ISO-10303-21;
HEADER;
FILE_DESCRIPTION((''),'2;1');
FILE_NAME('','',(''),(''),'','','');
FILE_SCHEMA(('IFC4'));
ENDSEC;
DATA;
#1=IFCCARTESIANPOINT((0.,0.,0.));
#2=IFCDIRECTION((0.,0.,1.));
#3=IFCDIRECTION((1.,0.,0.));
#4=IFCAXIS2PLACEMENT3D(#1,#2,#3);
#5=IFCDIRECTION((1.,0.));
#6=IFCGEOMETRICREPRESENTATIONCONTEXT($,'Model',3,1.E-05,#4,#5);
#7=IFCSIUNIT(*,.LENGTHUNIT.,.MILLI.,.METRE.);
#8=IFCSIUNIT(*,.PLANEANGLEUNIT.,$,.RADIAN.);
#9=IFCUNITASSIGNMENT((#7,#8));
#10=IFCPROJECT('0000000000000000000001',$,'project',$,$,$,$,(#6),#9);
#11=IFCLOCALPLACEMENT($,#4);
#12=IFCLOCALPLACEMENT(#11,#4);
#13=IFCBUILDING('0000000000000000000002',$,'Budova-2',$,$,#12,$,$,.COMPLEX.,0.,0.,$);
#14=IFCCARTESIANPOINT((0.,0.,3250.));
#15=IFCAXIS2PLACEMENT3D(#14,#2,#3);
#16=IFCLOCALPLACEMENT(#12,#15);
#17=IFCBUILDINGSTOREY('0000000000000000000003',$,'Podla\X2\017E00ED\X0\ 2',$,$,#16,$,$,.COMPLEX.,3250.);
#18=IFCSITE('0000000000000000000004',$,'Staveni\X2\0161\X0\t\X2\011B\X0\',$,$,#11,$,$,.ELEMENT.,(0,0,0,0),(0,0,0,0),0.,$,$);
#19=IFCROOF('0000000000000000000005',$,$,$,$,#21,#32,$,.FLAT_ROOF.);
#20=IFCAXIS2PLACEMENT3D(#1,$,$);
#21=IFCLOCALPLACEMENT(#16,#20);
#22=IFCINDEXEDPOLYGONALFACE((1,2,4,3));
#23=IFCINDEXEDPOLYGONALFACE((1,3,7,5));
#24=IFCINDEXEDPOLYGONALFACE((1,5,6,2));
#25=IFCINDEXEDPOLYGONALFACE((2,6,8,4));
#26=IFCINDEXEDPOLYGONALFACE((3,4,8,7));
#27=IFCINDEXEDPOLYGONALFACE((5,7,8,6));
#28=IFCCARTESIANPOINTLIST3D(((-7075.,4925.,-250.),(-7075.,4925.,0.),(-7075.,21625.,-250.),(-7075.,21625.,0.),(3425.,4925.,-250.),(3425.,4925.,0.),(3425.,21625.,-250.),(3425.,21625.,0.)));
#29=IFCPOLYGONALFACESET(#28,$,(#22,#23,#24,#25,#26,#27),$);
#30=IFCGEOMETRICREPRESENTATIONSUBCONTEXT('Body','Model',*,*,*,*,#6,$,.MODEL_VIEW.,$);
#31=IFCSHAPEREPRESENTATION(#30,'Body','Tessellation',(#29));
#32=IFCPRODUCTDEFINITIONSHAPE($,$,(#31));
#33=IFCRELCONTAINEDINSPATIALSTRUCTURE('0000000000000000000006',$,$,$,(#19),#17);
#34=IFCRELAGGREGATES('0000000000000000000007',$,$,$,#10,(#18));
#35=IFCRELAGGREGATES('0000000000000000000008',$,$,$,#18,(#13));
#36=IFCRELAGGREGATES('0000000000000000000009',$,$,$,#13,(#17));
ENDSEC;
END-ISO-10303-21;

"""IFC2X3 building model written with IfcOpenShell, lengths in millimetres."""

from ifc_helpers import new_model, si_unit, direction, frame, frame_2d, origin_with_axes, place, context, subcontext, project, spatial, rectangle, extrude, element, save


model = new_model("IFC2X3")

# Units and contexts
model_context = context("Model", 3, precision=1e-05, world=origin_with_axes(), true_north=direction((1.0, 0.0)))
body_context = subcontext(model_context, "Body", "Model", "MODEL_VIEW")
ifc_project = project(units=[si_unit("LENGTHUNIT", "METRE", prefix="MILLI"), si_unit("PLANEANGLEUNIT", "RADIAN")], contexts=[model_context])

# Site, building, storey
site_placement = place(None, origin_with_axes())
site = spatial("IfcSite", under=ifc_project, at=site_placement, Name="Staveniště", CompositionType="ELEMENT", RefLatitude=(0, 0, 0, 0), RefLongitude=(0, 0, 0, 0), RefElevation=0.0)
building_placement = place(site_placement, origin_with_axes())
building = spatial("IfcBuilding", under=site, at=building_placement, Name="Budova-2", CompositionType="COMPLEX", ElevationOfRefHeight=0.0, ElevationOfTerrain=0.0)
storey_placement = place(building_placement, frame((0.0, 0.0, 3250.0), z_axis=(0.0, 0.0, 1.0), x_axis=(1.0, 0.0, 0.0)))
storey = spatial("IfcBuildingStorey", under=building, at=storey_placement, Name="Podlaží 2", CompositionType="COMPLEX", Elevation=3250.0)

# Roof
roof_placement = place(storey_placement, frame((-7075.0, 21625.0, -250.0), z_axis=(0.0, 0.0, 1.0), x_axis=(0.0, -1.0, 0.0)))
element("IfcRoof", 1, at=roof_placement, inside=storey, ShapeType="FLAT_ROOF", context=body_context, shape_type="SweptSolid", body=[
    extrude(rectangle(XDim=16700.0, YDim=10500.0, at=frame_2d((0.0, 0.0), x_axis=(-1.0, 0.0))), frame((8350.0, 5250.0, 0.0), z_axis=(0.0, 0.0, 1.0), x_axis=(1.0, 0.0, 0.0)), (0.0, 0.0, 1.0), 250.0),
])

save(model, "model.ifc")
